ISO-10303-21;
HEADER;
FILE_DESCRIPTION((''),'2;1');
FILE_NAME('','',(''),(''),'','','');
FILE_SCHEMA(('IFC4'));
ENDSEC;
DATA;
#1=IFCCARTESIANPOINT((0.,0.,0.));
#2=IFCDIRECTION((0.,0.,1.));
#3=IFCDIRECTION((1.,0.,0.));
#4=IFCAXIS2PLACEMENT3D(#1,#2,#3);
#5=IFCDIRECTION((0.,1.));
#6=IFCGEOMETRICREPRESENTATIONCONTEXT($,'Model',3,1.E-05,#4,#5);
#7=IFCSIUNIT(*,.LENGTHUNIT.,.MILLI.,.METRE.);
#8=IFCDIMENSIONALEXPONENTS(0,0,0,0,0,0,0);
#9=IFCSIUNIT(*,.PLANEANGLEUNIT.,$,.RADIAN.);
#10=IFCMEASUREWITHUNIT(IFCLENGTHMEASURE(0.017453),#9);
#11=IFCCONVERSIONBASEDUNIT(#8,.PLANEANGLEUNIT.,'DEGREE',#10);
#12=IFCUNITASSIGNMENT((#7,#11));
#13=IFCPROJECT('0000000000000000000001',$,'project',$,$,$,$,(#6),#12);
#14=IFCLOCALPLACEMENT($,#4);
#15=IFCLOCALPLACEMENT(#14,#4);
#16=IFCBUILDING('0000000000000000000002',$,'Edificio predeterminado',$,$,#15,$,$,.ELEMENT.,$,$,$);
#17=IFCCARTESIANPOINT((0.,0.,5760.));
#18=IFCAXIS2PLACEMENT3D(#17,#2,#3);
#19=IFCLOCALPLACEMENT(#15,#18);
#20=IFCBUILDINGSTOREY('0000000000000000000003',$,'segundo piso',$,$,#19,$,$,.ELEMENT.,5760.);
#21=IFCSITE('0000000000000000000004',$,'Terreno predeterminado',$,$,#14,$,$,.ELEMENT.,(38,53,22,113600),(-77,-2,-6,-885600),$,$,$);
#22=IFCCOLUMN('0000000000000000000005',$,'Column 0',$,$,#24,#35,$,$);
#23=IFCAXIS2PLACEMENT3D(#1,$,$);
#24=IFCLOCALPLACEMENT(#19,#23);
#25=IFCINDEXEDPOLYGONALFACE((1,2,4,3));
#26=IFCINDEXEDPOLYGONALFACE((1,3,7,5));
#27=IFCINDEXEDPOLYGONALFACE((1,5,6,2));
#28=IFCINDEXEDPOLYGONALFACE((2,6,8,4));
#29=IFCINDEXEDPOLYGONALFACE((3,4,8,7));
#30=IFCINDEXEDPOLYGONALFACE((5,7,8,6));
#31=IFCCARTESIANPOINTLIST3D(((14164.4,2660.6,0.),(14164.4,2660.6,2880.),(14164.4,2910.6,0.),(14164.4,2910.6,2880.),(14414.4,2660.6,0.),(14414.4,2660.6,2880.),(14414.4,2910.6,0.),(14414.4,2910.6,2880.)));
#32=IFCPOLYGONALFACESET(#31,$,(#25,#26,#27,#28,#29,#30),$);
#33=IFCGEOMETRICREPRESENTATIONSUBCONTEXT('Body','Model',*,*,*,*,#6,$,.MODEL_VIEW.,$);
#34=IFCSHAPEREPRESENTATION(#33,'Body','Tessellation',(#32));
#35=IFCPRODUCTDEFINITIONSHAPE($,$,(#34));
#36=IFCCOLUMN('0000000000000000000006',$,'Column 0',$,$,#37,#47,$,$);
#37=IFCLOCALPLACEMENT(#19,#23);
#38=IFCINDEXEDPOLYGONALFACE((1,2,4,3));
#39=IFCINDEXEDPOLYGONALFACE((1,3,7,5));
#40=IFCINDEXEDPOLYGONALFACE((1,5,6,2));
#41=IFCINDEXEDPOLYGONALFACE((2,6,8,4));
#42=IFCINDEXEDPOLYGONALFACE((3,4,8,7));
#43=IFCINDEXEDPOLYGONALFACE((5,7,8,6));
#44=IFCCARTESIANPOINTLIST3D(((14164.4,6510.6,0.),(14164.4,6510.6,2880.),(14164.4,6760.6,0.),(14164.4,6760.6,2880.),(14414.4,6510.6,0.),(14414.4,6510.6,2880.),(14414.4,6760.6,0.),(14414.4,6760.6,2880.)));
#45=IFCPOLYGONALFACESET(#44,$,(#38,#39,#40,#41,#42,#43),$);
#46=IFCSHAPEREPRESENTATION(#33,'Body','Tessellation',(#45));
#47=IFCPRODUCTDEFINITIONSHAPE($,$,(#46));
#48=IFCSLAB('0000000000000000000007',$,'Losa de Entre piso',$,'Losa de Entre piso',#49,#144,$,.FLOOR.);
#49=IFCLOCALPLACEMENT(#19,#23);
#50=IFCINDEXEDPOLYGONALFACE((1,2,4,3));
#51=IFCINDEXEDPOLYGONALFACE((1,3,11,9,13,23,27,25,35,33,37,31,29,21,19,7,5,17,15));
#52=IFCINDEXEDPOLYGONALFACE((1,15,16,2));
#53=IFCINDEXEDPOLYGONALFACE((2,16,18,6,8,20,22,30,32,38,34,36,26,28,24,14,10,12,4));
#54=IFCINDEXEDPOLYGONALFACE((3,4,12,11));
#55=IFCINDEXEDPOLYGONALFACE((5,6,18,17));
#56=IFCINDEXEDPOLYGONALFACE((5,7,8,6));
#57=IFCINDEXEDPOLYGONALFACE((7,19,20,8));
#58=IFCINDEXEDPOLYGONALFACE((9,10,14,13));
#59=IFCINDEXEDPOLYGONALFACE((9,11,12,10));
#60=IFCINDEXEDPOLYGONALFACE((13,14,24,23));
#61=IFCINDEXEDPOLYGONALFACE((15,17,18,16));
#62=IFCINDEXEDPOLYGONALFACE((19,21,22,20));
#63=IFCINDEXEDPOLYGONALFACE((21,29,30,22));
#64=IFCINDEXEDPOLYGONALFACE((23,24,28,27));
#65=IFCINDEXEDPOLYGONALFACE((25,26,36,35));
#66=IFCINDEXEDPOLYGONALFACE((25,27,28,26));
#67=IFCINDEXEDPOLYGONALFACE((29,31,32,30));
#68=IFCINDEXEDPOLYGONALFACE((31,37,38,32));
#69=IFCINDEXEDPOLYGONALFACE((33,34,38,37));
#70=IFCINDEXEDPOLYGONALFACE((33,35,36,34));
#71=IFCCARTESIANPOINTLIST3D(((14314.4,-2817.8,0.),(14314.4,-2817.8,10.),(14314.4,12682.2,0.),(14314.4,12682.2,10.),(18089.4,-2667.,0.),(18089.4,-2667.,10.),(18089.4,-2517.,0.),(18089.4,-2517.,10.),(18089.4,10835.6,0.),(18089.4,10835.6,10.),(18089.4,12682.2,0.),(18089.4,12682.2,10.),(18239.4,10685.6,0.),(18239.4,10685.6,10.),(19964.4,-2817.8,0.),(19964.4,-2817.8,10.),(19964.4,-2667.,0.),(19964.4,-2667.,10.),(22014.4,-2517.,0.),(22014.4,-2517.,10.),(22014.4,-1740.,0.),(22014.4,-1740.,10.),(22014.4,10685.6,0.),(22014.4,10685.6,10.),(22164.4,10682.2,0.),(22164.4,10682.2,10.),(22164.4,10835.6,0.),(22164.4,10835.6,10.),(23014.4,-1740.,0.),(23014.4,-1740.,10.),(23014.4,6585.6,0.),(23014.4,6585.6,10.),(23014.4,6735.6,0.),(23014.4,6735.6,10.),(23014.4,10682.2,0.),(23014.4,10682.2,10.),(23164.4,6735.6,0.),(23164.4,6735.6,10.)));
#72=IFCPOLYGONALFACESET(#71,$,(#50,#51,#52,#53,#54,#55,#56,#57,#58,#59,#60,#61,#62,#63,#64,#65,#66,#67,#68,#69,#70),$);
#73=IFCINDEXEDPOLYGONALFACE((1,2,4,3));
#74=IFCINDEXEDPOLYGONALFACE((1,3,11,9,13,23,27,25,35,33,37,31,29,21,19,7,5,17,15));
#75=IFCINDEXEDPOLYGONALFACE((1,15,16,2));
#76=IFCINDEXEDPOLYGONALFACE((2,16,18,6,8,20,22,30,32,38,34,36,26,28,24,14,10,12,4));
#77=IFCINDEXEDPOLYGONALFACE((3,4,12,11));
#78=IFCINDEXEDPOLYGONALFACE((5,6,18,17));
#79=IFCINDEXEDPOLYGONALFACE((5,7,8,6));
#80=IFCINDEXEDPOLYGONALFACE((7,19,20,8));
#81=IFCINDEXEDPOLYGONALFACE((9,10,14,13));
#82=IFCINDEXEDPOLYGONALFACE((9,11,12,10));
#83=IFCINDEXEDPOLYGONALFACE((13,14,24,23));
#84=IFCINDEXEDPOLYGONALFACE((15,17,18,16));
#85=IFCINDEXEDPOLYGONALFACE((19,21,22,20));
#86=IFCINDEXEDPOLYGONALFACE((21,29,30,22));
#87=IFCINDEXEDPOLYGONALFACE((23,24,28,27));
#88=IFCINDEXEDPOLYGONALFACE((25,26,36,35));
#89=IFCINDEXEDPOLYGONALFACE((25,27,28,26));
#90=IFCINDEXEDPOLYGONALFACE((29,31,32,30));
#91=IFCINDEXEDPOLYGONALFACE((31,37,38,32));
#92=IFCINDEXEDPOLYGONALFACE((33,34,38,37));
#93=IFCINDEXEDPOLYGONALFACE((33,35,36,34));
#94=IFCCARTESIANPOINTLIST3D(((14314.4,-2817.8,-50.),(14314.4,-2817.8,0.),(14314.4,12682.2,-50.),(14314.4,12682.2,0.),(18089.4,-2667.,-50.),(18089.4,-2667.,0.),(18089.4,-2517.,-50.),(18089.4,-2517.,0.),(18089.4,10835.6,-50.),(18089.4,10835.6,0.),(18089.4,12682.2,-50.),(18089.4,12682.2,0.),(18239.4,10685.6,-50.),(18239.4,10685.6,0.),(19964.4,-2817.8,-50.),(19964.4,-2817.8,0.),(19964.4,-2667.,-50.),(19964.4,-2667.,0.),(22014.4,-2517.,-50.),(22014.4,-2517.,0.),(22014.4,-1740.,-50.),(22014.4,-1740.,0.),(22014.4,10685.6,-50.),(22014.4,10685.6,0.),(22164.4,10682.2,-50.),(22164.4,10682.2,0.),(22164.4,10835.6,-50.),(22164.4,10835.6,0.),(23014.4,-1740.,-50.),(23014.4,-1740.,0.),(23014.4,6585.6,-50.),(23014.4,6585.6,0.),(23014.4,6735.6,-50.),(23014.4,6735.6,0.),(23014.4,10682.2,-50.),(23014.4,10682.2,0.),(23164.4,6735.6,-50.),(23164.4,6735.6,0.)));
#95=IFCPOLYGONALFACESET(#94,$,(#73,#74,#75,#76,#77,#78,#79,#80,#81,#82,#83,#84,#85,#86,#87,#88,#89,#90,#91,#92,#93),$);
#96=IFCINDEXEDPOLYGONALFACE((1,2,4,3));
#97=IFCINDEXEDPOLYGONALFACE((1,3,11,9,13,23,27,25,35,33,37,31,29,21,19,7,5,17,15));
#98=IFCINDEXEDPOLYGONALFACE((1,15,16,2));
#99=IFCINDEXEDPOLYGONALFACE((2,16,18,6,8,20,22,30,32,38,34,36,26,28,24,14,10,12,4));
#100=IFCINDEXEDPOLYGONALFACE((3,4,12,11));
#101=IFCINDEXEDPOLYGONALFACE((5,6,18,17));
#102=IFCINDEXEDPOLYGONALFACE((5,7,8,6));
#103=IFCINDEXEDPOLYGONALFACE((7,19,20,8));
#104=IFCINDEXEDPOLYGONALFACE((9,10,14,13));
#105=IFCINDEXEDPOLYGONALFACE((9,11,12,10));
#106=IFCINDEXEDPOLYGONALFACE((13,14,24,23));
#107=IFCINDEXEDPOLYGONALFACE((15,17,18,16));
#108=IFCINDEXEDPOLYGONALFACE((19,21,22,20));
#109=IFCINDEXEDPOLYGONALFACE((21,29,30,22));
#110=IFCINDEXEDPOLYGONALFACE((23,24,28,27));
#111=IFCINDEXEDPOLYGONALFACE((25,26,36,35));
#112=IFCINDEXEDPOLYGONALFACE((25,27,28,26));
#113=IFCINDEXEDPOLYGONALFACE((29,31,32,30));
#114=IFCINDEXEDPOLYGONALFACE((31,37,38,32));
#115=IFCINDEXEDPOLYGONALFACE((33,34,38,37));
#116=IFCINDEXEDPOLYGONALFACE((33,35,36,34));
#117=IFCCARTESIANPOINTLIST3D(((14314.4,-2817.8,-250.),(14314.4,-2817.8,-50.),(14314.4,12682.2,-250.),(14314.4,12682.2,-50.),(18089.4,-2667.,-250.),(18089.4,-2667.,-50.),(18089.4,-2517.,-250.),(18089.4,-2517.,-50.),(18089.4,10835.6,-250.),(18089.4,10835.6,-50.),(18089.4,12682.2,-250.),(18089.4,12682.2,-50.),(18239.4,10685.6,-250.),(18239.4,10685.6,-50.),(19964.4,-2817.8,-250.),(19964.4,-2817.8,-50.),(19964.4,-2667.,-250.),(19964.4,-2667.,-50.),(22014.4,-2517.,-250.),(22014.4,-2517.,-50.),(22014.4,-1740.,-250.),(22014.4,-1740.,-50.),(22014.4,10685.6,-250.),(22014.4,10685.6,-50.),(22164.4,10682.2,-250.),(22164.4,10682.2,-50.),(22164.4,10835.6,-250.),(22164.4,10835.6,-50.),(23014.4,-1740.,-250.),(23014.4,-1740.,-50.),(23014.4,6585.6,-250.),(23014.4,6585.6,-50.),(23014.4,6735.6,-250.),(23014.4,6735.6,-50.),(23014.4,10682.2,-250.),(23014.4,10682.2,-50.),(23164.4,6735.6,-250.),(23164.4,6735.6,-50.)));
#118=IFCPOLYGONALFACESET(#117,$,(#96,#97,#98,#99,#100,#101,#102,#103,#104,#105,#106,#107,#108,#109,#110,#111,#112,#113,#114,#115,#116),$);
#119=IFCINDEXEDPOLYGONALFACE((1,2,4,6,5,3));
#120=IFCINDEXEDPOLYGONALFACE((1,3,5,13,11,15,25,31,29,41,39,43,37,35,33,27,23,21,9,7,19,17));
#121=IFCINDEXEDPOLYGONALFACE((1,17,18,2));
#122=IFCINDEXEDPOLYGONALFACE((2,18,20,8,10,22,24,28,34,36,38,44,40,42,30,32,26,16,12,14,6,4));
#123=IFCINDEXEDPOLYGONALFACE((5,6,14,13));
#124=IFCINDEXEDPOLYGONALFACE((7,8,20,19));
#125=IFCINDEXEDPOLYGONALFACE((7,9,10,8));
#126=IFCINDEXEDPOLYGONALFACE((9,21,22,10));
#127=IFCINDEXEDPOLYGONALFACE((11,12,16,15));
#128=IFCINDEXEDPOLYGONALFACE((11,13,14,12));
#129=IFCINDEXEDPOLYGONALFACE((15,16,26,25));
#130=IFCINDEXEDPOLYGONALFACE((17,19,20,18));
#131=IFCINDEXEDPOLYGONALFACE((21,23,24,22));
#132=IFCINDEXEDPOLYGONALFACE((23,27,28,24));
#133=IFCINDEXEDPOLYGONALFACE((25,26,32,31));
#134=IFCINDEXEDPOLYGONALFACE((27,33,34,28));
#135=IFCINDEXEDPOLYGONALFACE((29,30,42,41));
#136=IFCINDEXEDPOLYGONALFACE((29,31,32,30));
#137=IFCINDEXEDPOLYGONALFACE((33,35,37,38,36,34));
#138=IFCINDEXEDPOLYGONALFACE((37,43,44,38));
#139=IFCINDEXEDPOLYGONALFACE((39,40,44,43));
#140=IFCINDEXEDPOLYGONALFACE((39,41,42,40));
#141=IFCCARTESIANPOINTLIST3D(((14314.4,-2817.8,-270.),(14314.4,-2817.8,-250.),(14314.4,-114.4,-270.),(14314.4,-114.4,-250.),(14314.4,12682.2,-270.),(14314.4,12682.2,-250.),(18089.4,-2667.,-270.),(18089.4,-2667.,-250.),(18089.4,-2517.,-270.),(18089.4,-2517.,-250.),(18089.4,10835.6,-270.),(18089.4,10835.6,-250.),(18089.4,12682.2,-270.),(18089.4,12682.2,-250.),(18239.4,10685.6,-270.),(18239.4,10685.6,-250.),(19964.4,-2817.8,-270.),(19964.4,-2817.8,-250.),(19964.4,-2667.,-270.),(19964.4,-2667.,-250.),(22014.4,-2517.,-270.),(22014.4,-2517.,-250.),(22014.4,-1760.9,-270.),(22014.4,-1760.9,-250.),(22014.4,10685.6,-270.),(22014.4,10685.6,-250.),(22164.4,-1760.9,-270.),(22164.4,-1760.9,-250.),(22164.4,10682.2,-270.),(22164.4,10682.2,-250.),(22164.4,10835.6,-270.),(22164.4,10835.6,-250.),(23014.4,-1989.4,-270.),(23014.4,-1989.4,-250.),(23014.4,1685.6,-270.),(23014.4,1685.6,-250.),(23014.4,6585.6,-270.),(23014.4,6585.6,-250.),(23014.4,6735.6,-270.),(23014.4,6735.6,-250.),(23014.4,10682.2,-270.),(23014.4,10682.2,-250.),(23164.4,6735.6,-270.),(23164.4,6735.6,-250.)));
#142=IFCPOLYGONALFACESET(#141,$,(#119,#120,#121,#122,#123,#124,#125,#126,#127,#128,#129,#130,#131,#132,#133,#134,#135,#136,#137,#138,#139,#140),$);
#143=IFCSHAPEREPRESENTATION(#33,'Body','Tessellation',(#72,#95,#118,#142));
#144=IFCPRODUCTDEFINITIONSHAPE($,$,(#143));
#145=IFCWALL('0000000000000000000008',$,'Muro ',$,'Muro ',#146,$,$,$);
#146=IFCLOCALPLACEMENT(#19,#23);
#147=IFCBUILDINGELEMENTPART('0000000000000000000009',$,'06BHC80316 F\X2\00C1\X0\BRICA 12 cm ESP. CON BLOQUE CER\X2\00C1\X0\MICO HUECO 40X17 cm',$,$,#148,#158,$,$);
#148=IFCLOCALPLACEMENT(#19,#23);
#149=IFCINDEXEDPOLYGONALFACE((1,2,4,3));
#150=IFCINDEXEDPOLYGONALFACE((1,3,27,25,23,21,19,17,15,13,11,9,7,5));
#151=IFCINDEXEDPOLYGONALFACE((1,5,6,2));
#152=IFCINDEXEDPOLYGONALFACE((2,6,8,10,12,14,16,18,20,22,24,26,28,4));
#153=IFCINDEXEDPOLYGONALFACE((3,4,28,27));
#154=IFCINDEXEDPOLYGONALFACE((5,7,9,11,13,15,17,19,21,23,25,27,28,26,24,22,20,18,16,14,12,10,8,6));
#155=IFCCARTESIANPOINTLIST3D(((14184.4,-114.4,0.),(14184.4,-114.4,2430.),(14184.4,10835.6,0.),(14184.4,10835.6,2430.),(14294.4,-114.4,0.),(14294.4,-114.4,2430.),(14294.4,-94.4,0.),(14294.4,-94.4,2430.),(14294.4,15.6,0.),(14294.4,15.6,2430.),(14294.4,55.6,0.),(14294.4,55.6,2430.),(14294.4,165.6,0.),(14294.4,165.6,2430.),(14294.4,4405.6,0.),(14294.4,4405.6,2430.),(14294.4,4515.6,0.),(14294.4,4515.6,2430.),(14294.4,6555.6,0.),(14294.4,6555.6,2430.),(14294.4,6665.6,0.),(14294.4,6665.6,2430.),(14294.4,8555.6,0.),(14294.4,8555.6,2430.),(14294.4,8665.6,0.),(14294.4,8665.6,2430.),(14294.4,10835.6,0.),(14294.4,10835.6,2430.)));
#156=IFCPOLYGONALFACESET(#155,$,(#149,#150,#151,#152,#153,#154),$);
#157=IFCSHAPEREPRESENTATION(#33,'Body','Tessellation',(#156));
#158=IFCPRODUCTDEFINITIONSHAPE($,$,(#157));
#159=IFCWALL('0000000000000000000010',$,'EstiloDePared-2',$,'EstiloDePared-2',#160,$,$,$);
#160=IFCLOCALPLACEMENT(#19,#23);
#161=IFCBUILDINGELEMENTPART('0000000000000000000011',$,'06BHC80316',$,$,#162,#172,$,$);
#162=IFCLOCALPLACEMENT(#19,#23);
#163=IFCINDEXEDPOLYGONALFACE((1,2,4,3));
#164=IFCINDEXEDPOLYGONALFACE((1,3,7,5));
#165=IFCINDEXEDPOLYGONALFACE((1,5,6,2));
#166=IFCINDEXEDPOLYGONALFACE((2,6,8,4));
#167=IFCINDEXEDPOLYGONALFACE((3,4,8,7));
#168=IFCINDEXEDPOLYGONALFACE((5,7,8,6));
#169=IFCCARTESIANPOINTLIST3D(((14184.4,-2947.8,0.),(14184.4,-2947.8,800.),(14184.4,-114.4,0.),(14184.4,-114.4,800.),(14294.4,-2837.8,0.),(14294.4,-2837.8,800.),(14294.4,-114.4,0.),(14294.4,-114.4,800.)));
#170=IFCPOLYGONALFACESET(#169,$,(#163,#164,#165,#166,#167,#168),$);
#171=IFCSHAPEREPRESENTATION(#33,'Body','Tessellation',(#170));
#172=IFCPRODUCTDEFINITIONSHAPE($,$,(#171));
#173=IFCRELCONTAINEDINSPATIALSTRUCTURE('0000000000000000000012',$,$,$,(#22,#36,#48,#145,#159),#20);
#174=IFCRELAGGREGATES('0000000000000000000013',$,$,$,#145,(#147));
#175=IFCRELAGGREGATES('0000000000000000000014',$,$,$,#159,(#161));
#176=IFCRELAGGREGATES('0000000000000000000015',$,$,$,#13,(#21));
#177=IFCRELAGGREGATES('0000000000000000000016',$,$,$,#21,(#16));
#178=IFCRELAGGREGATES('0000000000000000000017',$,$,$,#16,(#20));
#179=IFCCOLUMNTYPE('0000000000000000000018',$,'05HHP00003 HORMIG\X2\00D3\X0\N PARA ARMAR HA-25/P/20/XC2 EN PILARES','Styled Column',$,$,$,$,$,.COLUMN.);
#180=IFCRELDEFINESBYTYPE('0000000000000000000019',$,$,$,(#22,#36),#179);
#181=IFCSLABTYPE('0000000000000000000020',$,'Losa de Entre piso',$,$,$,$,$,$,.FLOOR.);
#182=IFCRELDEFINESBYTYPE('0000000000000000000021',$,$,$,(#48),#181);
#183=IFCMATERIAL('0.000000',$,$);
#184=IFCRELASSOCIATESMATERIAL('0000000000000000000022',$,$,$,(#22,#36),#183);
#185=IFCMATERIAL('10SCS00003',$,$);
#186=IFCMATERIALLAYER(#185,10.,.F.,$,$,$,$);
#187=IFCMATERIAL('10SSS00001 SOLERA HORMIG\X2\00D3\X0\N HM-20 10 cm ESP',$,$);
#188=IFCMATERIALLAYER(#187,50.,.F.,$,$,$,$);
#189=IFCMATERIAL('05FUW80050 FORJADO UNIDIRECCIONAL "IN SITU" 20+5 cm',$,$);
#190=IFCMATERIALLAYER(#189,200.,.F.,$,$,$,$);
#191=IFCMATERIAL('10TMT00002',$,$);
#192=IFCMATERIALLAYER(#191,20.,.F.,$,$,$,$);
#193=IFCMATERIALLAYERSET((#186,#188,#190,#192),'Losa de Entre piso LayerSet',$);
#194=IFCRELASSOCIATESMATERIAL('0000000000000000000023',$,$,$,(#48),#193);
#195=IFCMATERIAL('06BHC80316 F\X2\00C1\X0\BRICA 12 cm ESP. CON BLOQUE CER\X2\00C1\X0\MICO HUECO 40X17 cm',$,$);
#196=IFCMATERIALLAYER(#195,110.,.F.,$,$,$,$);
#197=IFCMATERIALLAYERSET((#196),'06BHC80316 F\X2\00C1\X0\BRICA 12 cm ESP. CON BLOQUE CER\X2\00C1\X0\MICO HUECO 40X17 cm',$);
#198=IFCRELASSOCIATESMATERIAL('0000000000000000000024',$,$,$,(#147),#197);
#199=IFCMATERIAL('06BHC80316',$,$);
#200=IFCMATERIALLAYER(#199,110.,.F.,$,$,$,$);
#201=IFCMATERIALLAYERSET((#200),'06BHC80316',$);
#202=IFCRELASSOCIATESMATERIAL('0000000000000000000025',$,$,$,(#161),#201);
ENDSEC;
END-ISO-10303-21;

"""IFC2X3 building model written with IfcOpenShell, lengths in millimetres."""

from ifc_helpers import new_model, entity, si_unit, converted_unit, direction, frame, origin_with_axes, place, context, subcontext, project, spatial, polyline, outline, extrude, material, layer, layer_set, layer_usage, type_object, element, aggregate, save


model = new_model("IFC2X3")

# Units and contexts
model_context = context("Model", 3, precision=1e-05, world=origin_with_axes(), true_north=direction((0.0, 1.0)))
body_context = subcontext(model_context, "Body", "Model", "MODEL_VIEW")
ifc_project = project(units=[si_unit("LENGTHUNIT", "METRE", prefix="MILLI"), converted_unit("PLANEANGLEUNIT", "DEGREE", entity("IfcLengthMeasure", 0.017453), si_unit("PLANEANGLEUNIT", "RADIAN"), dimensions=[0, 0, 0, 0, 0, 0, 0])], contexts=[model_context])

# Site, building, storey
site_placement = place(None, origin_with_axes())
site = spatial("IfcSite", under=ifc_project, at=site_placement, Name="Terreno predeterminado", CompositionType="ELEMENT", RefLatitude=(38, 53, 22, 113600), RefLongitude=(-77, -2, -6, -885600))
building_placement = place(site_placement, origin_with_axes())
building = spatial("IfcBuilding", under=site, at=building_placement, Name="Edificio predeterminado", CompositionType="ELEMENT")
storey_placement = place(building_placement, frame((0.0, 0.0, 5760.0), z_axis=(0.0, 0.0, 1.0), x_axis=(1.0, 0.0, 0.0)))
storey = spatial("IfcBuildingStorey", under=building, at=storey_placement, Name="segundo piso", CompositionType="ELEMENT", Elevation=5760.0)

# Columns
ifc_material_1 = material(Name="0.000000")
column_type = type_object("IfcColumnType", Name="05HHP00003 HORMIGÓN PARA ARMAR HA-25/P/20/XC2 EN PILARES", Description="Styled Column", PredefinedType="COLUMN")
for number, where, z_axis, x_axis, name in (
    (1, (14289.4, 2785.6, 0.0), (0.0, 0.0, 1.0), (1.0, 0.0, 0.0), "Column 0"),
    (2, (14289.4, 6635.6, 0.0), (0.0, 0.0, 1.0), (1.0, 0.0, 0.0), "Column 0"),
):
    element("IfcColumn", number, at=place(storey_placement, frame(where, z_axis=z_axis, x_axis=x_axis)), inside=storey, type_object=column_type, material=ifc_material_1, Name=name, context=body_context, shape_type="SweptSolid", body=[
        extrude(outline(polyline([(-125.0, -125.0), (125.0, -125.0), (125.0, 125.0), (-125.0, 125.0), (-125.0, -125.0)])), origin_with_axes(), (0.0, 0.0, 1.0), 2880.0),
    ])

# Slab
ifc_material_2 = material(Name="10SCS00003")
ifc_layer_1 = layer(ifc_material_2, 10.0, ventilated=False)
ifc_material_3 = material(Name="10SSS00001 SOLERA HORMIGÓN HM-20 10 cm ESP")
ifc_layer_2 = layer(ifc_material_3, 50.0, ventilated=False)
ifc_material_4 = material(Name="05FUW80050 FORJADO UNIDIRECCIONAL \"IN SITU\" 20+5 cm")
ifc_layer_3 = layer(ifc_material_4, 200.0, ventilated=False)
ifc_material_5 = material(Name="10TMT00002")
ifc_layer_4 = layer(ifc_material_5, 20.0, ventilated=False)
ifc_layer_set_1 = layer_set([ifc_layer_1, ifc_layer_2, ifc_layer_3, ifc_layer_4], Name="Losa de Entre piso LayerSet")
ifc_layer_usage_1 = layer_usage(ifc_layer_set_1, "AXIS3", "POSITIVE", 0.0)
slab_type = type_object("IfcSlabType", Name="Losa de Entre piso", PredefinedType="FLOOR")
slab_placement = place(storey_placement, frame((0.0, 0.0, -5760.0), z_axis=(0.0, 0.0, 1.0), x_axis=(1.0, 0.0, 0.0)))
element("IfcSlab", 3, at=slab_placement, inside=storey, type_object=slab_type, material=ifc_layer_usage_1, Name="Losa de Entre piso", ObjectType="Losa de Entre piso", PredefinedType="FLOOR", context=body_context, shape_type="SweptSolid", body=[
    extrude(outline(polyline([(0.0, -777.0), (-1000.0, -777.0), (-1000.0, -9102.6), (-1150.0, -9252.6), (-1000.0, -9252.6), (-1000.0, -13199.1), (-150.0, -13199.1), (-150.0, -13352.6), (0.0, -13202.6), (3775.0, -13202.6), (3925.0, -13352.6), (3925.0, -15199.1), (7700.0, -15199.1), (7700.0, 300.9), (2050.0, 300.9), (2050.0, 150.0), (3925.0, 150.0), (3925.0, 0.0), (0.0, 0.0), (0.0, -777.0)])), frame((22014.4, -2517.0, 5760.0), z_axis=(0.0, 0.0, 1.0), x_axis=(-1.0, 0.0, 0.0)), (0.0, 0.0, 1.0), 10.0),
    extrude(outline(polyline([(0.0, -777.0), (-1000.0, -777.0), (-1000.0, -9102.6), (-1150.0, -9252.6), (-1000.0, -9252.6), (-1000.0, -13199.1), (-150.0, -13199.1), (-150.0, -13352.6), (0.0, -13202.6), (3775.0, -13202.6), (3925.0, -13352.6), (3925.0, -15199.1), (7700.0, -15199.1), (7700.0, 300.9), (2050.0, 300.9), (2050.0, 150.0), (3925.0, 150.0), (3925.0, 0.0), (0.0, 0.0), (0.0, -777.0)])), frame((22014.4, -2517.0, 5710.0), z_axis=(0.0, 0.0, 1.0), x_axis=(-1.0, 0.0, 0.0)), (0.0, 0.0, 1.0), 50.0),
    extrude(outline(polyline([(0.0, -777.0), (-1000.0, -777.0), (-1000.0, -9102.6), (-1150.0, -9252.6), (-1000.0, -9252.6), (-1000.0, -13199.1), (-150.0, -13199.1), (-150.0, -13352.6), (0.0, -13202.6), (3775.0, -13202.6), (3925.0, -13352.6), (3925.0, -15199.1), (7700.0, -15199.1), (7700.0, 300.9), (2050.0, 300.9), (2050.0, 150.0), (3925.0, 150.0), (3925.0, 0.0), (0.0, 0.0), (0.0, -777.0)])), frame((22014.4, -2517.0, 5510.0), z_axis=(0.0, 0.0, 1.0), x_axis=(-1.0, 0.0, 0.0)), (0.0, 0.0, 1.0), 200.0),
    extrude(outline(polyline([(-1305.7, 1305.7), (-3975.1, -1363.6), (5073.5, -10412.1), (6985.1, -12323.8), (10980.3, -8328.6), (10873.6, -8221.9), (9547.8, -9547.8), (9441.7, -9441.7), (12217.1, -6666.3), (11682.5, -6131.7), (11788.6, -6025.7), (12551.1, -5586.1), (9952.5, -2987.5), (6487.7, 477.3), (6487.7, 689.4), (6381.6, 583.4), (3591.0, 3374.0), (2990.0, 2773.0), (2881.5, 2881.5), (2881.5, 2669.3), (212.1, 0.0), (0.0, 0.0), (-1305.7, 1305.7)])), frame((18089.4, 10835.6, 5490.0), z_axis=(0.0, 0.0, 1.0), x_axis=(0.707107, -0.707107, 0.0)), (0.0, 0.0, 1.0), 20.0),
])

# Walls, building element parts
wall_1_placement = place(storey_placement, frame((14239.4, 10835.6, 0.0), z_axis=(0.0, 0.0, 1.0), x_axis=(0.0, -1.0, 0.0)))
wall_1 = element("IfcWall", 4, at=wall_1_placement, inside=storey, Name="Muro ", ObjectType="Muro ")
ifc_material_6 = material(Name="06BHC80316 FÁBRICA 12 cm ESP. CON BLOQUE CERÁMICO HUECO 40X17 cm")
ifc_layer_5 = layer(ifc_material_6, 110.0, ventilated=False)
ifc_layer_set_2 = layer_set([ifc_layer_5], Name="06BHC80316 FÁBRICA 12 cm ESP. CON BLOQUE CERÁMICO HUECO 40X17 cm")
ifc_layer_usage_2 = layer_usage(ifc_layer_set_2, "AXIS2", "NEGATIVE", -55.0)
building_element_part_1_placement = place(wall_1_placement, origin_with_axes())
building_element_part_1 = element("IfcBuildingElementPart", 5, at=building_element_part_1_placement, material=ifc_layer_usage_2, Name="06BHC80316 FÁBRICA 12 cm ESP. CON BLOQUE CERÁMICO HUECO 40X17 cm", context=body_context, shape_type="SweptSolid", body=[
    extrude(outline(polyline([(4280.0, 55.0), (6320.0, 55.0), (6430.0, 55.0), (10670.0, 55.0), (10780.0, 55.0), (10820.0, 55.0), (10930.0, 55.0), (10950.0, 55.0), (10950.0, -55.0), (0.0, -55.0), (0.0, 55.0), (2170.0, 55.0), (2280.0, 55.0), (4170.0, 55.0), (4280.0, 55.0)])), origin_with_axes(), (0.0, 0.0, 1.0), 2430.0),
])
aggregate(wall_1, [building_element_part_1])
wall_2_placement = place(storey_placement, frame((14239.4, -2892.8, 0.0), z_axis=(0.0, 0.0, 1.0), x_axis=(0.0, 1.0, 0.0)))
wall_2 = element("IfcWall", 6, at=wall_2_placement, inside=storey, Name="EstiloDePared-2", ObjectType="EstiloDePared-2")
ifc_material_7 = material(Name="06BHC80316")
ifc_layer_6 = layer(ifc_material_7, 110.0, ventilated=False)
ifc_layer_set_3 = layer_set([ifc_layer_6], Name="06BHC80316")
ifc_layer_usage_3 = layer_usage(ifc_layer_set_3, "AXIS2", "NEGATIVE", -55.0)
building_element_part_2_placement = place(wall_2_placement, origin_with_axes())
building_element_part_2 = element("IfcBuildingElementPart", 7, at=building_element_part_2_placement, material=ifc_layer_usage_3, Name="06BHC80316", context=body_context, shape_type="SweptSolid", body=[
    extrude(outline(polyline([(2778.4, 55.0), (2778.4, -55.0), (55.0, -55.0), (-55.0, 55.0), (2778.4, 55.0)])), origin_with_axes(), (0.0, 0.0, 1.0), 800.0),
])
aggregate(wall_2, [building_element_part_2])

save(model, "model.ifc")
